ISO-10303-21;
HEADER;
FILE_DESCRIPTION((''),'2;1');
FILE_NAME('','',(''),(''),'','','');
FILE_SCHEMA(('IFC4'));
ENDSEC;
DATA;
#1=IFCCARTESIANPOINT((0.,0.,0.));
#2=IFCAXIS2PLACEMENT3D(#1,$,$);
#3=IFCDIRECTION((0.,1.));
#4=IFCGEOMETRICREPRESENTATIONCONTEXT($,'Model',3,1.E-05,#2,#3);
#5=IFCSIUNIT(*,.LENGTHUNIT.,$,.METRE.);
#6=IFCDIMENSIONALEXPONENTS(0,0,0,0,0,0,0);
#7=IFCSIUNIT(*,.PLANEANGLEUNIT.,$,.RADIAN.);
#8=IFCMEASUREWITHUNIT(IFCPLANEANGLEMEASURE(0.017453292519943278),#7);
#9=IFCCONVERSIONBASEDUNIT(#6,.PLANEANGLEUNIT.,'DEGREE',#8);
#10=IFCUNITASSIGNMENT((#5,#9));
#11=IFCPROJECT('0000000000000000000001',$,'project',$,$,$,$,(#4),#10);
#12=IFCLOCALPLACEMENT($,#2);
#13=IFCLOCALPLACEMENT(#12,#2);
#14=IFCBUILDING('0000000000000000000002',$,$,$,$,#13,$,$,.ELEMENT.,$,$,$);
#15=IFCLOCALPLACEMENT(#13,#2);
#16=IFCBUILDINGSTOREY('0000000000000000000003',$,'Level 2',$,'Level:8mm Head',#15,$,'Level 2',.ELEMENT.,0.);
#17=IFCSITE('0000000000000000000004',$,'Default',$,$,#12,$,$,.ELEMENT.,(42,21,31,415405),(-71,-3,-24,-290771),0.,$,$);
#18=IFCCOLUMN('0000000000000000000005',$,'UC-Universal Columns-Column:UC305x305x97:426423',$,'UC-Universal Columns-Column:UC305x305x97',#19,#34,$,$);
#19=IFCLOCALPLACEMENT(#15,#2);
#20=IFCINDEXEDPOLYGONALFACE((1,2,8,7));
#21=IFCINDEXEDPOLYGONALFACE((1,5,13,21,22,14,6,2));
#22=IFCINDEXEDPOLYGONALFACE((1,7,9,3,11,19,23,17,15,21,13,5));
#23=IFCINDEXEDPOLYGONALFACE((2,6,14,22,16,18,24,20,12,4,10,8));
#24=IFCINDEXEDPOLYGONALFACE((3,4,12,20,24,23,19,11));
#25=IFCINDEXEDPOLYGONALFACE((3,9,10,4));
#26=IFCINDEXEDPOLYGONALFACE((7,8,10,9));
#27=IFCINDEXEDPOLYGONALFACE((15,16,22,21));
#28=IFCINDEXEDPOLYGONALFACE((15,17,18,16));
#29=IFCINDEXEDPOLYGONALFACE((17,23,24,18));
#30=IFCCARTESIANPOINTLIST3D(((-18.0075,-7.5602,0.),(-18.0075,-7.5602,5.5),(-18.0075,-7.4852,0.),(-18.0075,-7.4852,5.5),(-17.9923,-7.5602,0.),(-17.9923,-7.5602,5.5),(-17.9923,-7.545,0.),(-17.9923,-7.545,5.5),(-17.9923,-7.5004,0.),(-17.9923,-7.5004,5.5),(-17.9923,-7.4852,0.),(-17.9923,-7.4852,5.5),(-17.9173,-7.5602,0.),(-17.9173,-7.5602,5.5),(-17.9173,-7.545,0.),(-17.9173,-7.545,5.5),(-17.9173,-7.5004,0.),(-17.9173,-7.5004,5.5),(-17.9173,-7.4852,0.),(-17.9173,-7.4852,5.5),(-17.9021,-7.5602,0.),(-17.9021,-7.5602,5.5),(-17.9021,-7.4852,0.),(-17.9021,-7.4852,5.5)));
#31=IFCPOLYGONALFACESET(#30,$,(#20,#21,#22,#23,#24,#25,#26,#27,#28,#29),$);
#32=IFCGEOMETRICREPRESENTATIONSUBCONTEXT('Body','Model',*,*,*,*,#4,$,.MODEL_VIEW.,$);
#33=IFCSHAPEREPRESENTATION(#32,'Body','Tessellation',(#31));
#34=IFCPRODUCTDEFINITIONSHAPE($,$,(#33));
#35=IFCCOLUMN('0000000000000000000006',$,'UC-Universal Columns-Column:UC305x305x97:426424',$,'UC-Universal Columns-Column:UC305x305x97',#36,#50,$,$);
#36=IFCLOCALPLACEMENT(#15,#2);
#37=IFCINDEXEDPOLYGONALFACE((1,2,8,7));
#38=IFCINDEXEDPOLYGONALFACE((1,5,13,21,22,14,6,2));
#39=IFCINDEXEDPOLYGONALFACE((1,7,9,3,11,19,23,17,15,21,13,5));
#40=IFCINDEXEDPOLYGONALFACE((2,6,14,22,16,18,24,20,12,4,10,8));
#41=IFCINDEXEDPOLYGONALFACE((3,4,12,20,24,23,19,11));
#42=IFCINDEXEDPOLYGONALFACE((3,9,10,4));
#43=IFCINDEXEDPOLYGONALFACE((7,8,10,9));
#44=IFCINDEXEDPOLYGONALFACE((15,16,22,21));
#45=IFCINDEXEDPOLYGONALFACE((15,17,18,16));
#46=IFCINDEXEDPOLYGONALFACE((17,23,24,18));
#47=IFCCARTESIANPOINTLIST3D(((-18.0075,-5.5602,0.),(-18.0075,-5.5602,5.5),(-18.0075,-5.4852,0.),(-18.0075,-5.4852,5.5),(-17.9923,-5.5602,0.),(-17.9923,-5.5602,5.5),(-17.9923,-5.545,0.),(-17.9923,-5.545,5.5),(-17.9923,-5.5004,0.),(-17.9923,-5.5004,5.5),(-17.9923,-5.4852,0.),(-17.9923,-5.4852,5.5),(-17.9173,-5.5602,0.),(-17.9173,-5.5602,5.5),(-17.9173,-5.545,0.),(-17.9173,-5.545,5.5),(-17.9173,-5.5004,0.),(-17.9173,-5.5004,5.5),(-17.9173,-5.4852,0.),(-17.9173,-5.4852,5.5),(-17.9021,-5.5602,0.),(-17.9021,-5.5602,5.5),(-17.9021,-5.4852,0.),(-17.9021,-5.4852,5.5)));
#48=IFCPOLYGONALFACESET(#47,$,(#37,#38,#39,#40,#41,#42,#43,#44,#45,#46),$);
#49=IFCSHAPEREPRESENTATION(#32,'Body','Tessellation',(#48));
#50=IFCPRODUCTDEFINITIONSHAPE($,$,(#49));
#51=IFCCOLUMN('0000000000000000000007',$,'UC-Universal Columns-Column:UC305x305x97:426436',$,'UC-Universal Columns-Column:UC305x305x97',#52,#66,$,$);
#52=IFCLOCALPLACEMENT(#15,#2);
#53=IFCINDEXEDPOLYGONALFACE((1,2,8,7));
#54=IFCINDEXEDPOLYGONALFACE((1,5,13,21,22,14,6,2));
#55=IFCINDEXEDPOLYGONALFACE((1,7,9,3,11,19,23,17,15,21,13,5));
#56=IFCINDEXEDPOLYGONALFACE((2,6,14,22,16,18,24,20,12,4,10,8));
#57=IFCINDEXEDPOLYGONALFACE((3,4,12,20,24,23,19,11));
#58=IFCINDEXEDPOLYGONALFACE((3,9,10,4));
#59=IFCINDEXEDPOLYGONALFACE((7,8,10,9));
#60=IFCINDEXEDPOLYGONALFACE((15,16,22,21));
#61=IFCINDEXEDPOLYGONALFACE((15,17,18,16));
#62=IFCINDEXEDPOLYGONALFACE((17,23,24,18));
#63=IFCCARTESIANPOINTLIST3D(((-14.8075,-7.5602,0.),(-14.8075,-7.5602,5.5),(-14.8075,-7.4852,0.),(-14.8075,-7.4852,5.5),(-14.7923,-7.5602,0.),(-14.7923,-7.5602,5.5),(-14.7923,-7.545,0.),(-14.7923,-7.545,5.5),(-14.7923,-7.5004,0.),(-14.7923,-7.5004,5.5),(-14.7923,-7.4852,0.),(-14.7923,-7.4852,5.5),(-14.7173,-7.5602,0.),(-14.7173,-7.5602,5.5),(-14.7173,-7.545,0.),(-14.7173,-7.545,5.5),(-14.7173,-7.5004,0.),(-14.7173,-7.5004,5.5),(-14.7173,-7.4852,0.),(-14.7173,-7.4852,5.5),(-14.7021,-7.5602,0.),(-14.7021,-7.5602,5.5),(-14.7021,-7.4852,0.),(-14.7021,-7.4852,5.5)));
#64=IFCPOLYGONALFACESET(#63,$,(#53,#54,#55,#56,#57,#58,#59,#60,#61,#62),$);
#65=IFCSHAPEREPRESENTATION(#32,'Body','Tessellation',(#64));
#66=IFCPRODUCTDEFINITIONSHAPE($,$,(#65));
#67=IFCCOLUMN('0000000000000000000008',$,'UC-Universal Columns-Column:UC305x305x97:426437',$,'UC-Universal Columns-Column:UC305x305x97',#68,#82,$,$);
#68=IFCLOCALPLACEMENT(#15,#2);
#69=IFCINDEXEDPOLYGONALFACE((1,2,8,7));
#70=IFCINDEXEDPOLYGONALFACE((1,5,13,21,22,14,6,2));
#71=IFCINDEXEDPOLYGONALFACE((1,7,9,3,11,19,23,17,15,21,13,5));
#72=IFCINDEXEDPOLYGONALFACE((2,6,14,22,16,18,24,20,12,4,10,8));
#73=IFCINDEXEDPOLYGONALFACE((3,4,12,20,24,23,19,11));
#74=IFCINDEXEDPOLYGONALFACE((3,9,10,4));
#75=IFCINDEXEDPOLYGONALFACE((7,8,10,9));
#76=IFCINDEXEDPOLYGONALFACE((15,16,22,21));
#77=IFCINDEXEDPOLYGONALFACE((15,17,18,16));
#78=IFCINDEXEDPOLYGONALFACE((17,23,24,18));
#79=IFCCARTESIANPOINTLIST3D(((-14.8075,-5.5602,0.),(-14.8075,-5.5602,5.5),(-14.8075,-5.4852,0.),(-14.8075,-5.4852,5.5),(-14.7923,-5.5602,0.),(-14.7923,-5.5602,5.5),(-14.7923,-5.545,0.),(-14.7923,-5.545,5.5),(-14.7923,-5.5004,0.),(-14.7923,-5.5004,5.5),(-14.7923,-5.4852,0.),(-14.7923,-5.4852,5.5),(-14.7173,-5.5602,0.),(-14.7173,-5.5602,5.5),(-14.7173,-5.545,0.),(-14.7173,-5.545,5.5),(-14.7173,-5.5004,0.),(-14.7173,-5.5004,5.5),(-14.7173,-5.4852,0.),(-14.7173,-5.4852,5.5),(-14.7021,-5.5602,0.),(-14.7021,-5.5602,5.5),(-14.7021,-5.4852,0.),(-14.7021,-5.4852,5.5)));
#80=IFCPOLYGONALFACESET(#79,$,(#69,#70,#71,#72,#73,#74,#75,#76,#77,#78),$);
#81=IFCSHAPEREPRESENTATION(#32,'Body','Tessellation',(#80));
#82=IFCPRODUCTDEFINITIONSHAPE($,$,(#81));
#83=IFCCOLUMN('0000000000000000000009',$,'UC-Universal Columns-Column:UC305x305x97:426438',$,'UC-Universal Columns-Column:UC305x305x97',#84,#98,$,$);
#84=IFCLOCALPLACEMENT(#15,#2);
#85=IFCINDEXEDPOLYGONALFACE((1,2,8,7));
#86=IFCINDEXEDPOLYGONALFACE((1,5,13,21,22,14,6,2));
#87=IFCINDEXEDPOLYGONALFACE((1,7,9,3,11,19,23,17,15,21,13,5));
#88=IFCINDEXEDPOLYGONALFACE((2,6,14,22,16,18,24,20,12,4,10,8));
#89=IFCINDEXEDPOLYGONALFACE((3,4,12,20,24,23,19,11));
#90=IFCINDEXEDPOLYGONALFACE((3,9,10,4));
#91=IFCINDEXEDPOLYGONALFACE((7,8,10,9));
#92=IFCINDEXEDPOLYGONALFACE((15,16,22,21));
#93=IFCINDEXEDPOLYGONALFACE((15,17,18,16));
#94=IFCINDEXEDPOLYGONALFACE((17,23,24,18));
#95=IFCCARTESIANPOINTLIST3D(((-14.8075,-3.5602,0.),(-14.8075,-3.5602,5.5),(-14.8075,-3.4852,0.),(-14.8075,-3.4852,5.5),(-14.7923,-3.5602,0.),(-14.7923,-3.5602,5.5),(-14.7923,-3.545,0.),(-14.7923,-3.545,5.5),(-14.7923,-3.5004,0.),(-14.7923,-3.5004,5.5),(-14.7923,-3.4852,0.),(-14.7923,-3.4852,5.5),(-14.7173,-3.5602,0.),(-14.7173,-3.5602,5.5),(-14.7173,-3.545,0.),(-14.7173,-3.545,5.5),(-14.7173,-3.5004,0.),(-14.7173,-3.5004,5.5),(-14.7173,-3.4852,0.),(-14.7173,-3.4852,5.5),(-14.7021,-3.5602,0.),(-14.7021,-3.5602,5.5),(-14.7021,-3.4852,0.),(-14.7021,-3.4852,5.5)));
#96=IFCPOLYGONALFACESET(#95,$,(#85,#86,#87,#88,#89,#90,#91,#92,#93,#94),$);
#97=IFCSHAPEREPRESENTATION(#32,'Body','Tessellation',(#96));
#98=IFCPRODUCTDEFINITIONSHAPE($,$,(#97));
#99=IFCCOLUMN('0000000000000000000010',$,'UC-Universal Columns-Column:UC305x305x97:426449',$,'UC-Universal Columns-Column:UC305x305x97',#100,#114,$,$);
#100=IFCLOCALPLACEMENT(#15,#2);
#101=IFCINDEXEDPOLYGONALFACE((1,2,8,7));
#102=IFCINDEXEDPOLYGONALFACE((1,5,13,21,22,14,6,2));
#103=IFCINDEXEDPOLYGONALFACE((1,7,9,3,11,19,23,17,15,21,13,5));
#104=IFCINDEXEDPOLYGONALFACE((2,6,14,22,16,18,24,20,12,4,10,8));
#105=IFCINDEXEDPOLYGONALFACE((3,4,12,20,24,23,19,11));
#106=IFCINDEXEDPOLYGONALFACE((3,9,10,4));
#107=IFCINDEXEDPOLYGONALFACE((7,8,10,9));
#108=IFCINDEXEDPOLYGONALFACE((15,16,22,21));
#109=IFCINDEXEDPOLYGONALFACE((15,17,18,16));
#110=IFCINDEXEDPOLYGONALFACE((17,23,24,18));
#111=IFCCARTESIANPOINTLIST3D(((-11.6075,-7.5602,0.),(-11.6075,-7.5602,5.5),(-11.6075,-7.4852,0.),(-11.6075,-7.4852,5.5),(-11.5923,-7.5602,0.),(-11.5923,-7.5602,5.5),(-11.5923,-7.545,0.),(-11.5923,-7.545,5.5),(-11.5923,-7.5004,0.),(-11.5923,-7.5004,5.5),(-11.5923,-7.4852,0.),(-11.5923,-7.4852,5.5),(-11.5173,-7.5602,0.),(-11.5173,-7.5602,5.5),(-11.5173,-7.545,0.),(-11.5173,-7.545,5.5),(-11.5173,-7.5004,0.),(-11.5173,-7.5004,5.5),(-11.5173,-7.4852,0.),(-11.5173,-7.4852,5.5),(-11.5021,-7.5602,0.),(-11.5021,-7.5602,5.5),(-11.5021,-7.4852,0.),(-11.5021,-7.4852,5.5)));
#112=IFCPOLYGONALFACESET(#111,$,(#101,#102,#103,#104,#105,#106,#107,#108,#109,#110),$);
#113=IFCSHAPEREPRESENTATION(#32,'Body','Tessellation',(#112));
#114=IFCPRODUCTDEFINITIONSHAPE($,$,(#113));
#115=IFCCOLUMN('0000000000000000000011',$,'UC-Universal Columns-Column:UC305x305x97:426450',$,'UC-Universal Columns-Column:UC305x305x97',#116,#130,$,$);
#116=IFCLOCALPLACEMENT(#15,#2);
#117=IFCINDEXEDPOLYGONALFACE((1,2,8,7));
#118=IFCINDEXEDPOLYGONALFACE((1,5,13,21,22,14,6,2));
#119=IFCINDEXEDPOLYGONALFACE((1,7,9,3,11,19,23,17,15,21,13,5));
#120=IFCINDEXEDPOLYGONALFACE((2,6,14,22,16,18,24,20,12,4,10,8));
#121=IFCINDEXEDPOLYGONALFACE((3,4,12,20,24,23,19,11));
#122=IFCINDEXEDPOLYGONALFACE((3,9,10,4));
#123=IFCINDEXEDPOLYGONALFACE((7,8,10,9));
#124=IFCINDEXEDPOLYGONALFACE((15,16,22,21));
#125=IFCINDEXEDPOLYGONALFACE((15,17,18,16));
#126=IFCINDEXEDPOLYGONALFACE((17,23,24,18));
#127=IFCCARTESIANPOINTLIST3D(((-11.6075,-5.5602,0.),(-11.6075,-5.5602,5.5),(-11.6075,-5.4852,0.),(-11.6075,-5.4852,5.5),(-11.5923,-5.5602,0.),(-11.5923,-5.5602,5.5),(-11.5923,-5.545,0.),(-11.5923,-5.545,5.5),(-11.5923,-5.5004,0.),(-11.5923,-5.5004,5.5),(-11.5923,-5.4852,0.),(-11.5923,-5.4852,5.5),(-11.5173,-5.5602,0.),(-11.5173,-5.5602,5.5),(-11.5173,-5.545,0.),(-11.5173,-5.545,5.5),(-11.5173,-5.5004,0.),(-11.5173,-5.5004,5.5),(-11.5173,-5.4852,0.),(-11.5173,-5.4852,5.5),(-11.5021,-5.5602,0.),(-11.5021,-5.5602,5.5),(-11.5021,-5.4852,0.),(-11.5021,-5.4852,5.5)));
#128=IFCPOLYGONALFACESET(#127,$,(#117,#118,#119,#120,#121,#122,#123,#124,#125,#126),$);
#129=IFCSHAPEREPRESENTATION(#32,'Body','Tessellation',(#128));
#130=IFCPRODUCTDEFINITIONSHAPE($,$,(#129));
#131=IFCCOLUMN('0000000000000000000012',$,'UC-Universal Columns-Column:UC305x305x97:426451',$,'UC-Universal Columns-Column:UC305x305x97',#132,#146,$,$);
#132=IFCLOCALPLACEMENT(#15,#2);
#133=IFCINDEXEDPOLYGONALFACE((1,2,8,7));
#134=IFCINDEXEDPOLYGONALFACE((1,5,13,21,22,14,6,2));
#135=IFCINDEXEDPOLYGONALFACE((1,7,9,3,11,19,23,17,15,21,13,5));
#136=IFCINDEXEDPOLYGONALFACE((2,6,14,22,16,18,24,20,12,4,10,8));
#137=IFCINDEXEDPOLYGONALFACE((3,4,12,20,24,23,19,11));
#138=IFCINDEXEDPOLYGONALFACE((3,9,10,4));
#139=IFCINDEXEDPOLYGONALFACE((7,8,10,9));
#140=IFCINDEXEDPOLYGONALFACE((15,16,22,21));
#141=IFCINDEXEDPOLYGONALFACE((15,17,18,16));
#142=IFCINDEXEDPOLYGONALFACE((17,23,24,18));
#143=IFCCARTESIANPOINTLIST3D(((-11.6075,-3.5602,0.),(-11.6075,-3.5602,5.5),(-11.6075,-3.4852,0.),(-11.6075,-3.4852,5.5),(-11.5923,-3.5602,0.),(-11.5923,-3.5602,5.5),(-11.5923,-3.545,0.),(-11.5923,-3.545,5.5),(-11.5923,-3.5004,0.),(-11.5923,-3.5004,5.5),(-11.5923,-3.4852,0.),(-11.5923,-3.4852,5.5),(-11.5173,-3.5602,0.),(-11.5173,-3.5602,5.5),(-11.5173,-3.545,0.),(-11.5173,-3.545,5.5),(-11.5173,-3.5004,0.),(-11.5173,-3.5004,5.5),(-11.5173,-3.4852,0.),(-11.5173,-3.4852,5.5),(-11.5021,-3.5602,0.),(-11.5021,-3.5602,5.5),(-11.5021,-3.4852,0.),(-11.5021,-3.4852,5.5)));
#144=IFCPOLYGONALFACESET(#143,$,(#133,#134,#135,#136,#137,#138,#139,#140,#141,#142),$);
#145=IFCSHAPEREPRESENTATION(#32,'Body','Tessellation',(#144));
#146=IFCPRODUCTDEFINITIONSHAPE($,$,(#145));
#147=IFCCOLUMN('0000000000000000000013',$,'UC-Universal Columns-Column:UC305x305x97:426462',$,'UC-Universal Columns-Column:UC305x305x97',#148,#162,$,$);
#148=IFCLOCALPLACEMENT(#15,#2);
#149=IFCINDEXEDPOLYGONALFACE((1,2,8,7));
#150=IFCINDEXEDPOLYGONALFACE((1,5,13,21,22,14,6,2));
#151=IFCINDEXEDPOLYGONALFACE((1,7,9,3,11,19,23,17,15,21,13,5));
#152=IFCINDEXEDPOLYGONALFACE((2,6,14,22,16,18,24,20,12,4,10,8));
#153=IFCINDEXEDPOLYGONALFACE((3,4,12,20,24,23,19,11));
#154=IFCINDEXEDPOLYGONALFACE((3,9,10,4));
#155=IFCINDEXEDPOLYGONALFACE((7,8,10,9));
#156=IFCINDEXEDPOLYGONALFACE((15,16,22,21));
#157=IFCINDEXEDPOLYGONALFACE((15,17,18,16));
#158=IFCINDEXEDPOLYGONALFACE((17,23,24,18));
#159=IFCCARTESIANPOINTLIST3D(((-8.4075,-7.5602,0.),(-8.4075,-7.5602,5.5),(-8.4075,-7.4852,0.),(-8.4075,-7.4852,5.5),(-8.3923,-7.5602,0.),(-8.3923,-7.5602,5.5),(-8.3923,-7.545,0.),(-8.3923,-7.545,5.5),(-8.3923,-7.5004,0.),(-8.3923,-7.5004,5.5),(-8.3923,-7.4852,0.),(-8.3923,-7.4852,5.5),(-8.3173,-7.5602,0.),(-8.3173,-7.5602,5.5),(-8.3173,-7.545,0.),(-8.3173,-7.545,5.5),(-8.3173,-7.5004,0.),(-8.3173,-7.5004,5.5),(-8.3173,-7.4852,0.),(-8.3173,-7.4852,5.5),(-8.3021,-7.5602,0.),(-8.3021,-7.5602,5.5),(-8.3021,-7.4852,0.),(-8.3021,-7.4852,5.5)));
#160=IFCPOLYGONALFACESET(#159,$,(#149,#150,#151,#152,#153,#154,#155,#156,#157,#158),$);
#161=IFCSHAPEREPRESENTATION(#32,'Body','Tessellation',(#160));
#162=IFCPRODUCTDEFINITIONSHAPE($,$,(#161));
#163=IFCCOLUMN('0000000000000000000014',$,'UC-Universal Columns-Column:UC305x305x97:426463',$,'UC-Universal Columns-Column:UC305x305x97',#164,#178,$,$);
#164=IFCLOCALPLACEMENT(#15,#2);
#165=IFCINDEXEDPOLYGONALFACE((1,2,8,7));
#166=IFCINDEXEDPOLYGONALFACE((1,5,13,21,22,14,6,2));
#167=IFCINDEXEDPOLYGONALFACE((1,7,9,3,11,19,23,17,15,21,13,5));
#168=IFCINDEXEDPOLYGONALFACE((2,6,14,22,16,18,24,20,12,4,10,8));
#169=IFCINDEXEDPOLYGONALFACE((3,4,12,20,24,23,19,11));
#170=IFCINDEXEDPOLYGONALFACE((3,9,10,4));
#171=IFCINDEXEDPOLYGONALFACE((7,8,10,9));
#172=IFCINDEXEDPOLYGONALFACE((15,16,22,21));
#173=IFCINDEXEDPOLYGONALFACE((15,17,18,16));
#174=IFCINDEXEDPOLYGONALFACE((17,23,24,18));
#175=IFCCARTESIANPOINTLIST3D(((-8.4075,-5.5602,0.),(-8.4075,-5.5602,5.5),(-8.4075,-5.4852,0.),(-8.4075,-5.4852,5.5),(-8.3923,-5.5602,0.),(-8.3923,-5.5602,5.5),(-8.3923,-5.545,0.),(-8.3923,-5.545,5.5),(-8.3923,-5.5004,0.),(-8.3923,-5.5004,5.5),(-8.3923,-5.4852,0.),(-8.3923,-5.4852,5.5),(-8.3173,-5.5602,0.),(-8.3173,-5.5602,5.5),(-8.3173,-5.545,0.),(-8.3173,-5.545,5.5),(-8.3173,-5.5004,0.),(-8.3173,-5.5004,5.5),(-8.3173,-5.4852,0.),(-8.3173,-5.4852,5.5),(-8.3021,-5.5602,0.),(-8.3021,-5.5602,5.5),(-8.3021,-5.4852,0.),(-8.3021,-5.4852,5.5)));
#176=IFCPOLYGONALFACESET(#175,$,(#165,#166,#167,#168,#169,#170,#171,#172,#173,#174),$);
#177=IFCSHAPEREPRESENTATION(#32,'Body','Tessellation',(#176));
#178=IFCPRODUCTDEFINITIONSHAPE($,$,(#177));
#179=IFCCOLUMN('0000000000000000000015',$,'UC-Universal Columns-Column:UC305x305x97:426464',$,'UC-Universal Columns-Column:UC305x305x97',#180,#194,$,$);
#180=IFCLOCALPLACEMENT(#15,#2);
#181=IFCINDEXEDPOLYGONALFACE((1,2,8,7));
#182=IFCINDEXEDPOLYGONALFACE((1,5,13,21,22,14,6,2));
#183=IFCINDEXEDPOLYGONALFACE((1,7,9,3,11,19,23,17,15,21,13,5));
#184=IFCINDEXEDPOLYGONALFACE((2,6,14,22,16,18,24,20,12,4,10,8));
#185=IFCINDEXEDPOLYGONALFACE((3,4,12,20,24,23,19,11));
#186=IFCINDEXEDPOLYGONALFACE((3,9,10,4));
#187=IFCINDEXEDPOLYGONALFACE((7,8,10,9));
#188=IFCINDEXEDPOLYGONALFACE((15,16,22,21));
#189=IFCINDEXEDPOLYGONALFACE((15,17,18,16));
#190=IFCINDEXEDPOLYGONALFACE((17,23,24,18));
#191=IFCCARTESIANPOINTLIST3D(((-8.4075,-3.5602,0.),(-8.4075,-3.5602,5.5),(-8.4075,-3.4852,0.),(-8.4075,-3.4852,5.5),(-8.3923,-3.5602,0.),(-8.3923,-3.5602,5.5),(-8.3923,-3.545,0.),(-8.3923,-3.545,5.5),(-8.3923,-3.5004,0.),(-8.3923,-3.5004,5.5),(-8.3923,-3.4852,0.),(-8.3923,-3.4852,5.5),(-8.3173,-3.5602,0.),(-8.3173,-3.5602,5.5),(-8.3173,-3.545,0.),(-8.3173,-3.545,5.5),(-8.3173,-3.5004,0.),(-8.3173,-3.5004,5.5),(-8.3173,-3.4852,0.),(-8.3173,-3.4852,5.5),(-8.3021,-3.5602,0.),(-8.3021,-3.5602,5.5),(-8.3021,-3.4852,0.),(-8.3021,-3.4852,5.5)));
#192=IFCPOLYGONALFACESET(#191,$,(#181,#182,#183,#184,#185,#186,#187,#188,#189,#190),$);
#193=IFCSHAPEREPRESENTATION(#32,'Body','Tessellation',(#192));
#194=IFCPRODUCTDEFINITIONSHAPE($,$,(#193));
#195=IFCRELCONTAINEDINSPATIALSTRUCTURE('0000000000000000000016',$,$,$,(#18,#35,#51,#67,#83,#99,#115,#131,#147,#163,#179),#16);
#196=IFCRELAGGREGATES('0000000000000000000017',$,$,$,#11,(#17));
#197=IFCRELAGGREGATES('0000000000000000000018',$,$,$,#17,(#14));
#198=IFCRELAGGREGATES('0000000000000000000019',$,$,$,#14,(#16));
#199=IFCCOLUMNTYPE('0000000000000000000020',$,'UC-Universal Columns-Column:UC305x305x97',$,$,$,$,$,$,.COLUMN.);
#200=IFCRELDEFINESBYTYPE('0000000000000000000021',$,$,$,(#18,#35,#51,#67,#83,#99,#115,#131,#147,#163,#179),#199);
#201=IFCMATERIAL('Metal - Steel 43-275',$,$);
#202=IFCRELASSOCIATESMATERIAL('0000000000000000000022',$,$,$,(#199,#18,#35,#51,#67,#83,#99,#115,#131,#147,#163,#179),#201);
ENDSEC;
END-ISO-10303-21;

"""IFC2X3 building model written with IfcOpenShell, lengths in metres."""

from ifc_helpers import new_model, entity, si_unit, converted_unit, direction, frame, frame_2d, origin, place, context, subcontext, project, spatial, polyline, circle_curve, parameter, trimmed, segment, composite_curve, outline, extrude, source, transform, mapped, material, type_object, type_shapes, element, save


model = new_model("IFC2X3")

# Units and contexts
model_context = context("Model", 3, precision=1e-05, world=origin(), true_north=direction((0.0, 1.0)))
body_context = subcontext(model_context, "Body", "Model", "MODEL_VIEW")
ifc_project = project(units=[si_unit("LENGTHUNIT", "METRE"), converted_unit("PLANEANGLEUNIT", "DEGREE", entity("IfcPlaneAngleMeasure", 0.017453292519943278), si_unit("PLANEANGLEUNIT", "RADIAN"), dimensions=[0, 0, 0, 0, 0, 0, 0])], contexts=[model_context])

# Site, building, storey
site_placement = place(None, origin())
site = spatial("IfcSite", under=ifc_project, at=site_placement, Name="Default", CompositionType="ELEMENT", RefLatitude=(42, 21, 31, 415405), RefLongitude=(-71, -3, -24, -290771), RefElevation=0.0)
building_placement = place(site_placement, origin())
building = spatial("IfcBuilding", under=site, at=building_placement, CompositionType="ELEMENT")
storey_placement = place(building_placement, origin())
storey = spatial("IfcBuildingStorey", under=building, at=storey_placement, Name="Level 2", ObjectType="Level:8mm Head", LongName="Level 2", CompositionType="ELEMENT", Elevation=0.0)

# Columns
ifc_material = material(Name="Metal - Steel 43-275")
column_type = type_object("IfcColumnType", Name="UC-Universal Columns-Column:UC305x305x97", PredefinedType="COLUMN", material=ifc_material)
shared_shape = source(origin(), body_context, "Body", "SweptSolid", [
    extrude(outline(composite_curve([segment(polyline([(-0.0375, -0.0375), (0.0375, -0.0375)]), True, "CONTINUOUS"), segment(polyline([(0.0375, -0.0375), (0.0527, -0.0375)]), True, "CONTINUOUS"), segment(trimmed(circle_curve(frame_2d((0.0527, -0.0223), x_axis=(-1.0, 0.0)), 0.0152), [parameter(0.0)], [parameter(90.0)], True, "PARAMETER"), False, "CONTINUOUS"), segment(polyline([(0.0375, -0.0223), (0.0375, 0.0223)]), True, "CONTINUOUS"), segment(trimmed(circle_curve(frame_2d((0.0527, 0.0223), x_axis=(-1.0, 0.0)), 0.0152), [parameter(270.0)], [parameter(0.0)], True, "PARAMETER"), False, "CONTINUOUS"), segment(polyline([(0.0527, 0.0375), (0.0375, 0.0375)]), True, "CONTINUOUS"), segment(polyline([(0.0375, 0.0375), (-0.0375, 0.0375)]), True, "CONTINUOUS"), segment(polyline([(-0.0375, 0.0375), (-0.0527, 0.0375)]), True, "CONTINUOUS"), segment(trimmed(circle_curve(frame_2d((-0.0527, 0.0223), x_axis=(-1.0, 0.0)), 0.0152), [parameter(180.0)], [parameter(270.0)], True, "PARAMETER"), False, "CONTINUOUS"), segment(polyline([(-0.0375, 0.0223), (-0.0375, -0.0223)]), True, "CONTINUOUS"), segment(trimmed(circle_curve(frame_2d((-0.0527, -0.0223), x_axis=(-1.0, 0.0)), 0.0152), [parameter(90.0)], [parameter(180.0)], True, "PARAMETER"), False, "CONTINUOUS"), segment(polyline([(-0.0527, -0.0375), (-0.0375, -0.0375)]), True, "CONTINUOUS")], self_intersect=False)), frame((0.0, 0.0, 0.0), z_axis=(0.0, 0.0, 1.0), x_axis=(-1.0, 0.0, 0.0)), (0.0, 0.0, 1.0), 5.5),
])
type_shapes(column_type, [shared_shape])
for number, where, z_axis, x_axis, name in (
    (1, (-17.9548, -7.5227, 0.0), (0.0, 0.0, 1.0), (-1.0, 0.0, 0.0), "UC-Universal Columns-Column:UC305x305x97:426423"),
    (2, (-17.9548, -5.5227, 0.0), (0.0, 0.0, 1.0), (-1.0, 0.0, 0.0), "UC-Universal Columns-Column:UC305x305x97:426424"),
    (3, (-14.7548, -7.5227, 0.0), (0.0, 0.0, 1.0), (-1.0, 0.0, 0.0), "UC-Universal Columns-Column:UC305x305x97:426436"),
    (4, (-14.7548, -5.5227, 0.0), (0.0, 0.0, 1.0), (-1.0, 0.0, 0.0), "UC-Universal Columns-Column:UC305x305x97:426437"),
    (5, (-14.7548, -3.5227, 0.0), (0.0, 0.0, 1.0), (-1.0, 0.0, 0.0), "UC-Universal Columns-Column:UC305x305x97:426438"),
    (6, (-11.5548, -7.5227, 0.0), (0.0, 0.0, 1.0), (-1.0, 0.0, 0.0), "UC-Universal Columns-Column:UC305x305x97:426449"),
    (7, (-11.5548, -5.5227, 0.0), (0.0, 0.0, 1.0), (-1.0, 0.0, 0.0), "UC-Universal Columns-Column:UC305x305x97:426450"),
    (8, (-11.5548, -3.5227, 0.0), (0.0, 0.0, 1.0), (-1.0, 0.0, 0.0), "UC-Universal Columns-Column:UC305x305x97:426451"),
    (9, (-8.3548, -7.5227, 0.0), (0.0, 0.0, 1.0), (-1.0, 0.0, 0.0), "UC-Universal Columns-Column:UC305x305x97:426462"),
    (10, (-8.3548, -5.5227, 0.0), (0.0, 0.0, 1.0), (-1.0, 0.0, 0.0), "UC-Universal Columns-Column:UC305x305x97:426463"),
    (11, (-8.3548, -3.5227, 0.0), (0.0, 0.0, 1.0), (-1.0, 0.0, 0.0), "UC-Universal Columns-Column:UC305x305x97:426464"),
):
    element("IfcColumn", number, at=place(storey_placement, frame(where, z_axis=z_axis, x_axis=x_axis)), inside=storey, type_object=column_type, material=ifc_material, Name=name, ObjectType="UC-Universal Columns-Column:UC305x305x97", context=body_context, shape_type="MappedRepresentation", body=[
        mapped(shared_shape, transform((0.0, 0.0, 0.0), scale=1.0)),
    ])

save(model, "model.ifc")
